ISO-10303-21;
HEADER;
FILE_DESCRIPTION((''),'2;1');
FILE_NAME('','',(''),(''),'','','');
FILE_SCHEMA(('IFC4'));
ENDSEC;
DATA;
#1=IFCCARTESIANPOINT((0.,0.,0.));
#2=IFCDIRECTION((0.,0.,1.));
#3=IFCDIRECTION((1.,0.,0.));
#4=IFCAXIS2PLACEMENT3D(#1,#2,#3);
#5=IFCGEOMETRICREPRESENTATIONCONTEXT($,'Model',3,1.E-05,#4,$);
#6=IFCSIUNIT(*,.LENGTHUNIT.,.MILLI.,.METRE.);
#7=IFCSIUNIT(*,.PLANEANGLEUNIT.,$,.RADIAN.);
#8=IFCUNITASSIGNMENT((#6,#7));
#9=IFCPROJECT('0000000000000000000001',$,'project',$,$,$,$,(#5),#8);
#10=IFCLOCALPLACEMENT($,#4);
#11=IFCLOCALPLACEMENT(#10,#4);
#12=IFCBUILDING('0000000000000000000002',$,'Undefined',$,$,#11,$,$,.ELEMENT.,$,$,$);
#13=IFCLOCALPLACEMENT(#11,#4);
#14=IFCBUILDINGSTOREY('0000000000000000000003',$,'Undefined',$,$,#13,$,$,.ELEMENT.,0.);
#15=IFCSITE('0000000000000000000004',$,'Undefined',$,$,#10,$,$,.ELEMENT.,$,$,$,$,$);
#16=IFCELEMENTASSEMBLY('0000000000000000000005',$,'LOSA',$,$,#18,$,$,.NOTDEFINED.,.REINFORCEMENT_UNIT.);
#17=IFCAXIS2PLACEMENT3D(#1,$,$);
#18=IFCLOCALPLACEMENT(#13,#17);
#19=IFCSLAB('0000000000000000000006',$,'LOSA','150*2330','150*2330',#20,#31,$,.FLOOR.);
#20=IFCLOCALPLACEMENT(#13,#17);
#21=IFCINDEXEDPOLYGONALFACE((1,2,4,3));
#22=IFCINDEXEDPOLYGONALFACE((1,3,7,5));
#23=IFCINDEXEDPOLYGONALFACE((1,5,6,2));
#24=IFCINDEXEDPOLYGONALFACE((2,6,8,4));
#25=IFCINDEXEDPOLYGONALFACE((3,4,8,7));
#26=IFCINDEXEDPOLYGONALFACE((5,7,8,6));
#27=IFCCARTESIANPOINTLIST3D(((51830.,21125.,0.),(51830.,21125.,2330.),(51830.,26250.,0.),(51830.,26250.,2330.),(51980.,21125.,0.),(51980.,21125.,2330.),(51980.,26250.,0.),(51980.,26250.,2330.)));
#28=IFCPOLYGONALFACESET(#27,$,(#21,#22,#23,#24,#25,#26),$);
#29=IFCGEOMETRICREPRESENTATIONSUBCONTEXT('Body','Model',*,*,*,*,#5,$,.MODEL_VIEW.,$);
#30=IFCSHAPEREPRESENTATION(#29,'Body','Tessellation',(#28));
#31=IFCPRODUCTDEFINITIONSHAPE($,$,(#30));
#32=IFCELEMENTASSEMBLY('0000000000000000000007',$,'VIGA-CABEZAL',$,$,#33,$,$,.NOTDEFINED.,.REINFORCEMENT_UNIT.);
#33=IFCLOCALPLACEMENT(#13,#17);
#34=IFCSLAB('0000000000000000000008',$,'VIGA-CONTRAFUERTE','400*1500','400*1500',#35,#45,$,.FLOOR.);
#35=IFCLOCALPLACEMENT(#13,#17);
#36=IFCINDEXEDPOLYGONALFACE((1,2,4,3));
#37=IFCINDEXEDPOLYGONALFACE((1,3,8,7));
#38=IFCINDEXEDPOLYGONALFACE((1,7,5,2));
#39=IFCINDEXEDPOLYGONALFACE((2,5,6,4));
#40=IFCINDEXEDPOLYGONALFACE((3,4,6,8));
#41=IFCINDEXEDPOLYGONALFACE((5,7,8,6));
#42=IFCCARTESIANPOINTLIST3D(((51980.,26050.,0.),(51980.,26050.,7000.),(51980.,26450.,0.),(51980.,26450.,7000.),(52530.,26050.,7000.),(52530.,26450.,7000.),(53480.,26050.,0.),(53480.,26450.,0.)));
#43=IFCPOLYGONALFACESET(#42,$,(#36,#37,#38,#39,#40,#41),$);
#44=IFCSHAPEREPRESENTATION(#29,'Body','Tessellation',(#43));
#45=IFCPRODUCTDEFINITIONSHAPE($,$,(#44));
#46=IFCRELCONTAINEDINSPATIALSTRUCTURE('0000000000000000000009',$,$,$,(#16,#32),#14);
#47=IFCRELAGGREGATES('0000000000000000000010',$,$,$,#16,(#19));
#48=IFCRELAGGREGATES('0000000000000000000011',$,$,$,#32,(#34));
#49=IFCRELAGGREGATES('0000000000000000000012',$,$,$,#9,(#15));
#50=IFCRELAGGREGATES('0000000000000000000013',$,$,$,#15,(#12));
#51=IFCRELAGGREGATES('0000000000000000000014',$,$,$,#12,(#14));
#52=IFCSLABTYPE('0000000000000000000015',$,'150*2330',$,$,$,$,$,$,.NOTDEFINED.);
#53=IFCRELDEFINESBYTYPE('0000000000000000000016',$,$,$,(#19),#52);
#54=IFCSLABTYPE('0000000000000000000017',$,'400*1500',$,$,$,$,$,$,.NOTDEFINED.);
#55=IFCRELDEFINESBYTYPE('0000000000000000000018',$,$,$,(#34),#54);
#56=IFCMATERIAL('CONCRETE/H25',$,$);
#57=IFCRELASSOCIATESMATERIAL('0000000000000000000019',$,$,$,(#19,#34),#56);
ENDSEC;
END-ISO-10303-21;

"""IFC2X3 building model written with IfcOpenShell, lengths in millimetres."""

from ifc_helpers import new_model, si_unit, frame, origin_with_axes, place, context, subcontext, project, spatial, polyline, outline, extrude, material, type_object, element, aggregate, save


model = new_model("IFC2X3")

# Units and contexts
model_context = context("Model", 3, precision=1e-05, world=origin_with_axes())
body_context = subcontext(model_context, "Body", "Model", "MODEL_VIEW")
ifc_project = project(units=[si_unit("LENGTHUNIT", "METRE", prefix="MILLI"), si_unit("PLANEANGLEUNIT", "RADIAN")], contexts=[model_context])

# Site, building, storey
site_placement = place(None, origin_with_axes())
site = spatial("IfcSite", under=ifc_project, at=site_placement, Name="Undefined", CompositionType="ELEMENT")
building_placement = place(site_placement, origin_with_axes())
building = spatial("IfcBuilding", under=site, at=building_placement, Name="Undefined", CompositionType="ELEMENT")
storey_placement = place(building_placement, origin_with_axes())
storey = spatial("IfcBuildingStorey", under=building, at=storey_placement, Name="Undefined", CompositionType="ELEMENT", Elevation=0.0)

# Element assemblies, slabs
assembly_1_placement = place(storey_placement, origin_with_axes())
assembly_1 = element("IfcElementAssembly", 1, at=assembly_1_placement, inside=storey, Name="LOSA", AssemblyPlace="NOTDEFINED", PredefinedType="REINFORCEMENT_UNIT")
ifc_material_1 = material(Name="CONCRETE/H25")
slab_type_1 = type_object("IfcSlabType", Name="150*2330", PredefinedType="NOTDEFINED")
slab_1_placement = place(assembly_1_placement, frame((51905.0, 26250.0, 0.0), z_axis=(-1.0, 0.0, 0.0), x_axis=(0.0, -1.0, 0.0)))
slab_1 = element("IfcSlab", 2, at=slab_1_placement, type_object=slab_type_1, material=ifc_material_1, Name="LOSA", Description="150*2330", ObjectType="150*2330", PredefinedType="FLOOR", context=body_context, shape_type="SweptSolid", body=[
    extrude(outline(polyline([(0.0, 0.0), (5125.0, 0.0), (5125.0, 2330.0), (0.0, 2330.0), (0.0, 0.0)])), frame((0.0, 0.0, -75.0), z_axis=(0.0, 0.0, 1.0), x_axis=(1.0, 0.0, 0.0)), (0.0, 0.0, 1.0), 150.0),
])
aggregate(assembly_1, [slab_1])
assembly_2_placement = place(storey_placement, origin_with_axes())
assembly_2 = element("IfcElementAssembly", 3, at=assembly_2_placement, inside=storey, Name="VIGA-CABEZAL", AssemblyPlace="NOTDEFINED", PredefinedType="REINFORCEMENT_UNIT")
slab_type_2 = type_object("IfcSlabType", Name="400*1500", PredefinedType="NOTDEFINED")
slab_2_placement = place(assembly_2_placement, frame((51980.0, 26250.0, 0.0), z_axis=(0.0, 1.0, 0.0), x_axis=(0.0, 0.0, 1.0)))
slab_2 = element("IfcSlab", 4, at=slab_2_placement, type_object=slab_type_2, material=ifc_material_1, Name="VIGA-CONTRAFUERTE", Description="400*1500", ObjectType="400*1500", PredefinedType="FLOOR", context=body_context, shape_type="SweptSolid", body=[
    extrude(outline(polyline([(0.0, 0.0), (7000.0, 0.0), (7000.0, 550.0), (0.0, 1500.0), (0.0, 0.0)])), frame((0.0, 0.0, -200.0), z_axis=(0.0, 0.0, 1.0), x_axis=(1.0, 0.0, 0.0)), (0.0, 0.0, 1.0), 400.0),
])

aggregate(assembly_2, [slab_2])

save(model, "model.ifc")
